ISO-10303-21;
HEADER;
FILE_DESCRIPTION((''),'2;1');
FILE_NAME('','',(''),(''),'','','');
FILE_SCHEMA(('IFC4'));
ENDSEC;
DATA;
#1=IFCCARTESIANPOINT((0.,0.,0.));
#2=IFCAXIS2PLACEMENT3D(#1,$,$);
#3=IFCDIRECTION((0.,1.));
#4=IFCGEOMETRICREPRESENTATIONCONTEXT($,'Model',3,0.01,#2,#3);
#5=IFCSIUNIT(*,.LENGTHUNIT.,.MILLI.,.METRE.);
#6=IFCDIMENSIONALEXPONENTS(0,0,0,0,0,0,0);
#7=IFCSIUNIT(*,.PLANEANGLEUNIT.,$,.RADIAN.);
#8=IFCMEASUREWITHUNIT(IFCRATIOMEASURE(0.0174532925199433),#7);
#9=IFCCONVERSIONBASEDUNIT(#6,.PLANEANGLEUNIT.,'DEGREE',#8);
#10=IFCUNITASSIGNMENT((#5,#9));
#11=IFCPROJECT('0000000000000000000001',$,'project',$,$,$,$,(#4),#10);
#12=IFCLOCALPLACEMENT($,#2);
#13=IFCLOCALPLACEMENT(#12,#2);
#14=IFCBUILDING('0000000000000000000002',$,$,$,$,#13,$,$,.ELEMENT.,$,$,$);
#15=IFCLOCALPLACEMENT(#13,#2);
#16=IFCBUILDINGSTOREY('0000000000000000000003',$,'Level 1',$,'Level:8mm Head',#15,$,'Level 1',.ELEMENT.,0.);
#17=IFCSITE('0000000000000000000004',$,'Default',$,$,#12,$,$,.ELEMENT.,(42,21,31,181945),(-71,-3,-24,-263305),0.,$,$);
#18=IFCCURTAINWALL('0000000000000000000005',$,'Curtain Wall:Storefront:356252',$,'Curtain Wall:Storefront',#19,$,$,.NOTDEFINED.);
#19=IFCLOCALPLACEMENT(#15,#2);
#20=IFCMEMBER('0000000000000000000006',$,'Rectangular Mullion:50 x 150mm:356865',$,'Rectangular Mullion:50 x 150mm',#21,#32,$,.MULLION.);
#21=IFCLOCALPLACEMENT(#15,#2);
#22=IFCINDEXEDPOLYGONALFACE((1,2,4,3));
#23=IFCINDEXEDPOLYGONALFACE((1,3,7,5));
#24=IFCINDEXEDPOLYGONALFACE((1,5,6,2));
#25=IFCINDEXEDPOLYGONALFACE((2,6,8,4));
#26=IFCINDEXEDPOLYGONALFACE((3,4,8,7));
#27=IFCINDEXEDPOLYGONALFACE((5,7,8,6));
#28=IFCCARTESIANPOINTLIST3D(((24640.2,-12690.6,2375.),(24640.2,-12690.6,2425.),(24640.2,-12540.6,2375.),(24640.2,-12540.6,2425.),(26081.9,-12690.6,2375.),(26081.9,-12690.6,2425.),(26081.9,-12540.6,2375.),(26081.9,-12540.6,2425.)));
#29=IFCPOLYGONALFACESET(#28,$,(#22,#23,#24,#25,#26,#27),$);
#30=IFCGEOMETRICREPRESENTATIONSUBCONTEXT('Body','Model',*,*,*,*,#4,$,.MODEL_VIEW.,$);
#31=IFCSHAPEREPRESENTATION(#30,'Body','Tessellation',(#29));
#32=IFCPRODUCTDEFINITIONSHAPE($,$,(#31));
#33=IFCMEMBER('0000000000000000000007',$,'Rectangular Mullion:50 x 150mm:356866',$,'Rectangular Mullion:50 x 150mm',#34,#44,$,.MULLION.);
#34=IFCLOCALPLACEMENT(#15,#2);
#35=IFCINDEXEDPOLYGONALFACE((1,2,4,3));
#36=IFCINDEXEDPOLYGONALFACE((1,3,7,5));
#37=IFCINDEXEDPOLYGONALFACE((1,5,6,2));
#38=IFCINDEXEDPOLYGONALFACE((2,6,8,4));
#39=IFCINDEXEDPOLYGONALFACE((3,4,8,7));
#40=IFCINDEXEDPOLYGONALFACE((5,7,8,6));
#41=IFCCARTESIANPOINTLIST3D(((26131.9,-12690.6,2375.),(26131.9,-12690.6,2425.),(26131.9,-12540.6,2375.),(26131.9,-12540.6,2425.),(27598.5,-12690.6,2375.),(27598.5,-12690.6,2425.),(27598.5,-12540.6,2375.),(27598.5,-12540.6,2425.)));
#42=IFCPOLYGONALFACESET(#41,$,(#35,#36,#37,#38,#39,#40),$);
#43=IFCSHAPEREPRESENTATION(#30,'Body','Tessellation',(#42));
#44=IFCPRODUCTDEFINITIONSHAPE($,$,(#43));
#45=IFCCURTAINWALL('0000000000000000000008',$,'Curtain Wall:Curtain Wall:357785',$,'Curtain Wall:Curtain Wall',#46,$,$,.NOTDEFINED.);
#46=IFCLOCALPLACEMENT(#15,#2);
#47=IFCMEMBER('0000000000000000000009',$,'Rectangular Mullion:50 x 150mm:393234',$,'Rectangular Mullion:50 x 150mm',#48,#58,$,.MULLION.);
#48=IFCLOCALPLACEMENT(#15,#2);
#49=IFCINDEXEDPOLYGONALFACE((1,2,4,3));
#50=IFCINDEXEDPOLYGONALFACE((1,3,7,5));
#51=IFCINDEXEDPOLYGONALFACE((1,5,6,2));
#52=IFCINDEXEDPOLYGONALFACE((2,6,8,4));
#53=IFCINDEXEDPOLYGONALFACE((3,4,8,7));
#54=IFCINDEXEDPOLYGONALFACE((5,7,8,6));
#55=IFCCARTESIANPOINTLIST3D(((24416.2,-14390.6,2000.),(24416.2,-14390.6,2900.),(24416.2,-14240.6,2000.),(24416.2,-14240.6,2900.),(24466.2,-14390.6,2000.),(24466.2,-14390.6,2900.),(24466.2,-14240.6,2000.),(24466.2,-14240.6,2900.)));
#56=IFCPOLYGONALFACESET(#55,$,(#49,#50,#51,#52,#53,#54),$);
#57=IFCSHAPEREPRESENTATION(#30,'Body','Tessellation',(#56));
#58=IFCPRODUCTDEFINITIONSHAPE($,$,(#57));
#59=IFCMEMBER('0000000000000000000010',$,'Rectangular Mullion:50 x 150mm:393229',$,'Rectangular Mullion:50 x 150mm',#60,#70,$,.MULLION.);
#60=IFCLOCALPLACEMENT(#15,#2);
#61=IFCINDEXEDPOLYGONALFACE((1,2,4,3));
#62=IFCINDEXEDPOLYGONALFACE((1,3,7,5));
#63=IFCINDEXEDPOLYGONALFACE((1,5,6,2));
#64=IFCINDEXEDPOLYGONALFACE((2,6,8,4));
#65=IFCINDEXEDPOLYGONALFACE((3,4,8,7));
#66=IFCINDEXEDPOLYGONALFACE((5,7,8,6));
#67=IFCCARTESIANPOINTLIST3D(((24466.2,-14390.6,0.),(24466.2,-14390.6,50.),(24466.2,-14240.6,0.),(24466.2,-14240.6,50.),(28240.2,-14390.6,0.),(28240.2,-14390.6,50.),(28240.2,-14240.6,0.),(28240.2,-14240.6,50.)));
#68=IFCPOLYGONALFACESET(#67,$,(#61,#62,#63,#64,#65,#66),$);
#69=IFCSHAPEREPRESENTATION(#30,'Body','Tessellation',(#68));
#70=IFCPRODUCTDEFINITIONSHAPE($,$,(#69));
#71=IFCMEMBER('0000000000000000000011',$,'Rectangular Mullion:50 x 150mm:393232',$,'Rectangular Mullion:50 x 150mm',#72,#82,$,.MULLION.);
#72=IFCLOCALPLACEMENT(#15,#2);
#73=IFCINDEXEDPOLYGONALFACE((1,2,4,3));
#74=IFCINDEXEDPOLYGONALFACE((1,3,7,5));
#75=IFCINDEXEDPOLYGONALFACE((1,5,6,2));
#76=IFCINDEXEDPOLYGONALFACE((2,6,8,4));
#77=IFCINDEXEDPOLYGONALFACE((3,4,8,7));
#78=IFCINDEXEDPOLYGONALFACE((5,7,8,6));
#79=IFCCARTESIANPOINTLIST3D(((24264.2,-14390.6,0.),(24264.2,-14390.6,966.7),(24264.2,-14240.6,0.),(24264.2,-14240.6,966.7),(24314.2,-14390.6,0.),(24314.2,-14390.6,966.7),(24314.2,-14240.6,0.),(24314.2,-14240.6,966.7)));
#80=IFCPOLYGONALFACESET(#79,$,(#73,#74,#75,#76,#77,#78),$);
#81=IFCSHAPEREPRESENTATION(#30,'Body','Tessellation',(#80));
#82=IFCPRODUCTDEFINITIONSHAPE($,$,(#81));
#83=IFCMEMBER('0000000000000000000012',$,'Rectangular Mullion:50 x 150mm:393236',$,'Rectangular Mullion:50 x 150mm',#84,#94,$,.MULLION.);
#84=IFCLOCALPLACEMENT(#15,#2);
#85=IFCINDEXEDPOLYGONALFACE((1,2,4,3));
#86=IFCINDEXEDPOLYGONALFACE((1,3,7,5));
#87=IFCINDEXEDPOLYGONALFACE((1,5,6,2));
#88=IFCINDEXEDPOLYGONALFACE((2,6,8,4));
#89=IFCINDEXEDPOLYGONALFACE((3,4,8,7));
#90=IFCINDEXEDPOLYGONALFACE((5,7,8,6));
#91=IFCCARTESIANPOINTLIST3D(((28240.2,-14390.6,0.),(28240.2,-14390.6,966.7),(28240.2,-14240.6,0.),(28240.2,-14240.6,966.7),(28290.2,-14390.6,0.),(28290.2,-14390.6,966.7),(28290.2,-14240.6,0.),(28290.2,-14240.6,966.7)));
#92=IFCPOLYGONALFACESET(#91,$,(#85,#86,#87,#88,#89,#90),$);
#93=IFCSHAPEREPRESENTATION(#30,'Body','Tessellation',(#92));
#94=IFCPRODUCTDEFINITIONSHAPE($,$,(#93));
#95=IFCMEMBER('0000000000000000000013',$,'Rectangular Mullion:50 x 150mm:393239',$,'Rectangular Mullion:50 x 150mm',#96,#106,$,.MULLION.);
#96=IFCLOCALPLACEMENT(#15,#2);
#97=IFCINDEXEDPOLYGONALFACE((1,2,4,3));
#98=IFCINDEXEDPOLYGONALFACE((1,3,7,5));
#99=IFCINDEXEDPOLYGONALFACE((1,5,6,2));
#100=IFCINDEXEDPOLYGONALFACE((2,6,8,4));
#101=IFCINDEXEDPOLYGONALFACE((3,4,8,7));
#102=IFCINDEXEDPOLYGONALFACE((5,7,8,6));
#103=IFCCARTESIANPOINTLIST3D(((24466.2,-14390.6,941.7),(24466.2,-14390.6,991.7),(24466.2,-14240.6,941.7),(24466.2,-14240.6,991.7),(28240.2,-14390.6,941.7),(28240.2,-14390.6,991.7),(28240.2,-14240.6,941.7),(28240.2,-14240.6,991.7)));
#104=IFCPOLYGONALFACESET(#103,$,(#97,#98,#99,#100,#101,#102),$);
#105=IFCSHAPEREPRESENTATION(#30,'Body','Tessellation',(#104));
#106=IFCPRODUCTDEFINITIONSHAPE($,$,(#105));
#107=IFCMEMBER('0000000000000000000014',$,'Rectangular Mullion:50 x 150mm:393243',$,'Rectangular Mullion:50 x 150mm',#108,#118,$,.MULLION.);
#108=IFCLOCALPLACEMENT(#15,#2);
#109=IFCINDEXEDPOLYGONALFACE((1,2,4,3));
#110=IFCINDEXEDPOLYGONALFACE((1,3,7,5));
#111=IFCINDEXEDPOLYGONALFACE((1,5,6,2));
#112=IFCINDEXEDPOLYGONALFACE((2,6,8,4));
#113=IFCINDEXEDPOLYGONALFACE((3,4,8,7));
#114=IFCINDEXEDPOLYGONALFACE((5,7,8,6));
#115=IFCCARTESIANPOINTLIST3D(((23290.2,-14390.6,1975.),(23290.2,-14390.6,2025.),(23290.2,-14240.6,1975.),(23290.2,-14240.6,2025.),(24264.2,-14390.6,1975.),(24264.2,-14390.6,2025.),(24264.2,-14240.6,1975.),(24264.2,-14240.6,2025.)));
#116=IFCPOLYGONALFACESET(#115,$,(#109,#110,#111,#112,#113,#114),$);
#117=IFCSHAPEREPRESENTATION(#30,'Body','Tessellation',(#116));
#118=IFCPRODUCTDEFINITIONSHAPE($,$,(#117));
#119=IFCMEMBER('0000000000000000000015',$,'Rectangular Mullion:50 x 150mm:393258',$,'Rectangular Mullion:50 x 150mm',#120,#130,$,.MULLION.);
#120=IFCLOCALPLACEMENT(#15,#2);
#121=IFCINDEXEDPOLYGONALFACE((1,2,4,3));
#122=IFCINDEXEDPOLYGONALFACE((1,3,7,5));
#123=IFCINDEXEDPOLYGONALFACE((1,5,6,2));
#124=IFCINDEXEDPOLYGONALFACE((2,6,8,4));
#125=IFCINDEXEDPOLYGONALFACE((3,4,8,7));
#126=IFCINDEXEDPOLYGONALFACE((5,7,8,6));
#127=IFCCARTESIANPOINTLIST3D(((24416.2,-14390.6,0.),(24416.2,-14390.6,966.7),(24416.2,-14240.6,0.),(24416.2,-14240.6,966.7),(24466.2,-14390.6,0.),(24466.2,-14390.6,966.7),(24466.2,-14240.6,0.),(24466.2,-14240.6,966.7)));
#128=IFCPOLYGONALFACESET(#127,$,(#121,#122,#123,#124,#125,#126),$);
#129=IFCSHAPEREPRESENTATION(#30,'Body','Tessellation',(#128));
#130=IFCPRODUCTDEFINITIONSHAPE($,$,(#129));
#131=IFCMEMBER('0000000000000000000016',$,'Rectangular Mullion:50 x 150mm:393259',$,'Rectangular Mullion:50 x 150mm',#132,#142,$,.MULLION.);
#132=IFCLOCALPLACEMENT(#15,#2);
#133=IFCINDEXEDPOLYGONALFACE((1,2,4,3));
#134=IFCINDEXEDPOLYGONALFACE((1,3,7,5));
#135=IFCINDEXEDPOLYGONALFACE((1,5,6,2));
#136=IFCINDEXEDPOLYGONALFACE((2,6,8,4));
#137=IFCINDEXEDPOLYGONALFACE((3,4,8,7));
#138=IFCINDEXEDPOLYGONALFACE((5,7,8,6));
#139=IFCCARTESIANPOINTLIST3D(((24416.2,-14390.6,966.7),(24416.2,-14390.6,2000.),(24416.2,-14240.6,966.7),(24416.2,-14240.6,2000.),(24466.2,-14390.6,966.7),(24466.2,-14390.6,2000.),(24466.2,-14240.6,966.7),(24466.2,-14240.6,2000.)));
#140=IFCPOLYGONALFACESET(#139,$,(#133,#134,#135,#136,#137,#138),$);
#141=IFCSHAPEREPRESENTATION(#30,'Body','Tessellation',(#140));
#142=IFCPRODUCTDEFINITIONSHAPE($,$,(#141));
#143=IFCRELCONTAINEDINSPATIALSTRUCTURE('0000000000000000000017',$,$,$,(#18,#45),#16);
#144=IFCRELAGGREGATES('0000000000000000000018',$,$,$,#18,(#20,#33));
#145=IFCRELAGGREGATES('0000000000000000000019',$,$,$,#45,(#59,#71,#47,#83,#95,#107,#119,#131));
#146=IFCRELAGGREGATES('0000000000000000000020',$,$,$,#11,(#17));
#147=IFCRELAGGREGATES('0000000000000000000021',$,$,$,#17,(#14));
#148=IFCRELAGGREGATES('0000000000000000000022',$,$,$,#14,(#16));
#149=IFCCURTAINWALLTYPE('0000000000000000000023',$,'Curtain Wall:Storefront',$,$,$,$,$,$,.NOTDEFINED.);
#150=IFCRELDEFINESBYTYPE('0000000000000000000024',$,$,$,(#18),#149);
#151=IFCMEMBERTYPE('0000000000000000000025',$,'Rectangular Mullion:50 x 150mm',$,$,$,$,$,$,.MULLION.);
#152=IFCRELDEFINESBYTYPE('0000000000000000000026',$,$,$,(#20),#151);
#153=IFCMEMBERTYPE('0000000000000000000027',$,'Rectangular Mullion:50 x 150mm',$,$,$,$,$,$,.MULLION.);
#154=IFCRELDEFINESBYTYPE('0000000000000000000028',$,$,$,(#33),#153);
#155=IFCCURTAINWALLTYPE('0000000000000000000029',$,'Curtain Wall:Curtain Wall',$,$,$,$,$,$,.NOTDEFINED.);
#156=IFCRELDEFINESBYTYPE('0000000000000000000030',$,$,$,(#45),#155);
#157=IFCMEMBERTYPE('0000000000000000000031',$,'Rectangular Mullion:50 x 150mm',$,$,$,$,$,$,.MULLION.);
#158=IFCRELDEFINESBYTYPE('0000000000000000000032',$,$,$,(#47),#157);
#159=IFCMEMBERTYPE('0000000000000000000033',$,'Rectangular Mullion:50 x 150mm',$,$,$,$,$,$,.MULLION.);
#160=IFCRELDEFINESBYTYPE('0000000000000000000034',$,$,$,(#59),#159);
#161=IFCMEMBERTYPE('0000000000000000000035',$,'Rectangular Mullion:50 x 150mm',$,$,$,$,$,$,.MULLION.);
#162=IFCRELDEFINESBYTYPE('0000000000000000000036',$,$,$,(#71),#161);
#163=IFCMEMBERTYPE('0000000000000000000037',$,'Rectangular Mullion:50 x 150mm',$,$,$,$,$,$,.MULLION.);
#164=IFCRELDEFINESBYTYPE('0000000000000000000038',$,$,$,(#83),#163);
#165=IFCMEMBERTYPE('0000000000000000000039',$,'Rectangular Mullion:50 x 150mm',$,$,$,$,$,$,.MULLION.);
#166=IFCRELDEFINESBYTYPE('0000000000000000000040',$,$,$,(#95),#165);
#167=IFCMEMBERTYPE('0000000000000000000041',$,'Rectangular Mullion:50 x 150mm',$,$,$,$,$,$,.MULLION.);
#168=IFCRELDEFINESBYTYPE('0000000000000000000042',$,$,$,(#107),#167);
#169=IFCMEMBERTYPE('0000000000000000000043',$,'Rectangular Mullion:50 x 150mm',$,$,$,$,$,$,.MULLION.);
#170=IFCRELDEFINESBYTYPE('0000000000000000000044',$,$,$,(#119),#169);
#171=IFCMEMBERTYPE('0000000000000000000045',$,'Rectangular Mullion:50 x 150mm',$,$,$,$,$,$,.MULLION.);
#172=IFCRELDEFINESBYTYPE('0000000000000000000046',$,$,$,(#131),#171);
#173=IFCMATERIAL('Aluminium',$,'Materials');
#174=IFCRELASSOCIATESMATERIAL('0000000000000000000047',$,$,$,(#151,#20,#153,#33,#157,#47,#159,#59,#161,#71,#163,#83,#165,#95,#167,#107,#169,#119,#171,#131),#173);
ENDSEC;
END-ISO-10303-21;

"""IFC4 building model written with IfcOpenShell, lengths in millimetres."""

from ifc_helpers import new_model, entity, si_unit, converted_unit, direction, frame, origin, place, context, subcontext, project, spatial, indexed_curve, outline, extrude, source, transform, mapped, material, type_object, type_shapes, element, aggregate, save


model = new_model("IFC4")

# Units and contexts
model_context = context("Model", 3, precision=0.01, world=origin(), true_north=direction((0.0, 1.0)))
body_context = subcontext(model_context, "Body", "Model", "MODEL_VIEW")
ifc_project = project(units=[si_unit("LENGTHUNIT", "METRE", prefix="MILLI"), converted_unit("PLANEANGLEUNIT", "DEGREE", entity("IfcRatioMeasure", 0.0174532925199433), si_unit("PLANEANGLEUNIT", "RADIAN"), dimensions=[0, 0, 0, 0, 0, 0, 0])], contexts=[model_context])

# Site, building, storey
site_placement = place(None, origin())
site = spatial("IfcSite", under=ifc_project, at=site_placement, Name="Default", CompositionType="ELEMENT", RefLatitude=(42, 21, 31, 181945), RefLongitude=(-71, -3, -24, -263305), RefElevation=0.0)
building_placement = place(site_placement, origin())
building = spatial("IfcBuilding", under=site, at=building_placement, CompositionType="ELEMENT")
storey_placement = place(building_placement, origin())
storey = spatial("IfcBuildingStorey", under=building, at=storey_placement, Name="Level 1", ObjectType="Level:8mm Head", LongName="Level 1", CompositionType="ELEMENT", Elevation=0.0)

# Curtain walls, members
curtain_wall_type_1 = type_object("IfcCurtainWallType", Name="Curtain Wall:Storefront", PredefinedType="NOTDEFINED")
curtain_wall_1_placement = place(storey_placement, origin())
curtain_wall_1 = element("IfcCurtainWall", 1, at=curtain_wall_1_placement, inside=storey, type_object=curtain_wall_type_1, Name="Curtain Wall:Storefront:356252", ObjectType="Curtain Wall:Storefront", PredefinedType="NOTDEFINED")
ifc_material_1 = material(Name="Aluminium", Category="Materials")
member_type_1 = type_object("IfcMemberType", Name="Rectangular Mullion:50 x 150mm", PredefinedType="MULLION", material=ifc_material_1)
shared_shape_1 = source(origin(), body_context, "Body", "SweptSolid", [
    extrude(outline(indexed_curve([(-75.0, -25.0), (75.0, -25.0), (75.0, 25.0), (-75.0, 25.0), (-75.0, -25.0)], self_intersect=False)), frame((0.0, 0.0, -1441.7), z_axis=(0.0, 0.0, 1.0), x_axis=(0.0, -1.0, 0.0)), (0.0, 0.0, 1.0), 1441.7),
])
type_shapes(member_type_1, [shared_shape_1])
member_1_placement = place(storey_placement, frame((26081.9, -12615.6, 2400.0), z_axis=(1.0, 0.0, 0.0), x_axis=(0.0, 0.0, 1.0)))
member_1 = element("IfcMember", 2, at=member_1_placement, type_object=member_type_1, material=ifc_material_1, Name="Rectangular Mullion:50 x 150mm:356865", ObjectType="Rectangular Mullion:50 x 150mm", PredefinedType="MULLION", context=body_context, shape_type="MappedRepresentation", body=[
    mapped(shared_shape_1, transform((0.0, 0.0, 0.0), scale=1.0)),
])
member_type_2 = type_object("IfcMemberType", Name="Rectangular Mullion:50 x 150mm", PredefinedType="MULLION", material=ifc_material_1)
shared_shape_2 = source(origin(), body_context, "Body", "SweptSolid", [
    extrude(outline(indexed_curve([(-75.0, -25.0), (75.0, -25.0), (75.0, 25.0), (-75.0, 25.0), (-75.0, -25.0)], self_intersect=False)), frame((0.0, 0.0, -1466.7), z_axis=(0.0, 0.0, 1.0), x_axis=(0.0, -1.0, 0.0)), (0.0, 0.0, 1.0), 1466.7),
])
type_shapes(member_type_2, [shared_shape_2])
member_2_placement = place(storey_placement, frame((27598.5, -12615.6, 2400.0), z_axis=(1.0, 0.0, 0.0), x_axis=(0.0, 0.0, 1.0)))
member_2 = element("IfcMember", 3, at=member_2_placement, type_object=member_type_2, material=ifc_material_1, Name="Rectangular Mullion:50 x 150mm:356866", ObjectType="Rectangular Mullion:50 x 150mm", PredefinedType="MULLION", context=body_context, shape_type="MappedRepresentation", body=[
    mapped(shared_shape_2, transform((0.0, 0.0, 0.0), scale=1.0)),
])
curtain_wall_type_2 = type_object("IfcCurtainWallType", Name="Curtain Wall:Curtain Wall", PredefinedType="NOTDEFINED")
curtain_wall_2_placement = place(storey_placement, origin())
curtain_wall_2 = element("IfcCurtainWall", 4, at=curtain_wall_2_placement, inside=storey, type_object=curtain_wall_type_2, Name="Curtain Wall:Curtain Wall:357785", ObjectType="Curtain Wall:Curtain Wall", PredefinedType="NOTDEFINED")
member_type_3 = type_object("IfcMemberType", Name="Rectangular Mullion:50 x 150mm", PredefinedType="MULLION", material=ifc_material_1)
shared_shape_3 = source(origin(), body_context, "Body", "SweptSolid", [
    extrude(outline(indexed_curve([(-75.0, -25.0), (75.0, -25.0), (75.0, 25.0), (-75.0, 25.0), (-75.0, -25.0)], self_intersect=False)), frame((-25.0, 0.0, -900.0), z_axis=(0.0, 0.0, 1.0), x_axis=(0.0, -1.0, 0.0)), (0.0, 0.0, 1.0), 900.0),
])
type_shapes(member_type_3, [shared_shape_3])
member_3_placement = place(storey_placement, frame((24416.2, -14315.6, 2900.0), z_axis=(0.0, 0.0, 1.0), x_axis=(-1.0, 0.0, 0.0)))
member_3 = element("IfcMember", 5, at=member_3_placement, type_object=member_type_3, material=ifc_material_1, Name="Rectangular Mullion:50 x 150mm:393234", ObjectType="Rectangular Mullion:50 x 150mm", PredefinedType="MULLION", context=body_context, shape_type="MappedRepresentation", body=[
    mapped(shared_shape_3, transform((0.0, 0.0, 0.0), scale=1.0)),
])
member_type_4 = type_object("IfcMemberType", Name="Rectangular Mullion:50 x 150mm", PredefinedType="MULLION", material=ifc_material_1)
shared_shape_4 = source(origin(), body_context, "Body", "SweptSolid", [
    extrude(outline(indexed_curve([(-75.0, -25.0), (75.0, -25.0), (75.0, 25.0), (-75.0, 25.0), (-75.0, -25.0)], self_intersect=False)), frame((-25.0, 0.0, -3774.0), z_axis=(0.0, 0.0, 1.0), x_axis=(0.0, -1.0, 0.0)), (0.0, 0.0, 1.0), 3774.0),
])
type_shapes(member_type_4, [shared_shape_4])
member_4_placement = place(storey_placement, frame((24466.2, -14315.6, 0.0), z_axis=(-1.0, 0.0, 0.0), x_axis=(0.0, 0.0, -1.0)))
member_4 = element("IfcMember", 6, at=member_4_placement, type_object=member_type_4, material=ifc_material_1, Name="Rectangular Mullion:50 x 150mm:393229", ObjectType="Rectangular Mullion:50 x 150mm", PredefinedType="MULLION", context=body_context, shape_type="MappedRepresentation", body=[
    mapped(shared_shape_4, transform((0.0, 0.0, 0.0), scale=1.0)),
])
member_type_5 = type_object("IfcMemberType", Name="Rectangular Mullion:50 x 150mm", PredefinedType="MULLION", material=ifc_material_1)
shared_shape_5 = source(origin(), body_context, "Body", "SweptSolid", [
    extrude(outline(indexed_curve([(-75.0, -25.0), (75.0, -25.0), (75.0, 25.0), (-75.0, 25.0), (-75.0, -25.0)], self_intersect=False)), frame((-25.0, 0.0, -966.7), z_axis=(0.0, 0.0, 1.0), x_axis=(0.0, -1.0, 0.0)), (0.0, 0.0, 1.0), 966.7),
])
type_shapes(member_type_5, [shared_shape_5])
member_5_placement = place(storey_placement, frame((24314.2, -14315.6, 0.0), z_axis=(0.0, 0.0, -1.0), x_axis=(1.0, 0.0, 0.0)))
member_5 = element("IfcMember", 7, at=member_5_placement, type_object=member_type_5, material=ifc_material_1, Name="Rectangular Mullion:50 x 150mm:393232", ObjectType="Rectangular Mullion:50 x 150mm", PredefinedType="MULLION", context=body_context, shape_type="MappedRepresentation", body=[
    mapped(shared_shape_5, transform((0.0, 0.0, 0.0), scale=1.0)),
])
member_type_6 = type_object("IfcMemberType", Name="Rectangular Mullion:50 x 150mm", PredefinedType="MULLION", material=ifc_material_1)
shared_shape_6 = source(origin(), body_context, "Body", "SweptSolid", [
    extrude(outline(indexed_curve([(-75.0, -25.0), (75.0, -25.0), (75.0, 25.0), (-75.0, 25.0), (-75.0, -25.0)], self_intersect=False)), frame((0.0, 0.0, -966.7), z_axis=(0.0, 0.0, 1.0), x_axis=(0.0, -1.0, 0.0)), (0.0, 0.0, 1.0), 966.7),
])
type_shapes(member_type_6, [shared_shape_6])
member_6_placement = place(storey_placement, frame((28265.2, -14315.6, 0.0), z_axis=(0.0, 0.0, -1.0), x_axis=(1.0, 0.0, 0.0)))
member_6 = element("IfcMember", 8, at=member_6_placement, type_object=member_type_6, material=ifc_material_1, Name="Rectangular Mullion:50 x 150mm:393236", ObjectType="Rectangular Mullion:50 x 150mm", PredefinedType="MULLION", context=body_context, shape_type="MappedRepresentation", body=[
    mapped(shared_shape_6, transform((0.0, 0.0, 0.0), scale=1.0)),
])
member_type_7 = type_object("IfcMemberType", Name="Rectangular Mullion:50 x 150mm", PredefinedType="MULLION", material=ifc_material_1)
shared_shape_7 = source(origin(), body_context, "Body", "SweptSolid", [
    extrude(outline(indexed_curve([(-75.0, -25.0), (75.0, -25.0), (75.0, 25.0), (-75.0, 25.0), (-75.0, -25.0)], self_intersect=False)), frame((0.0, 0.0, -3774.0), z_axis=(0.0, 0.0, 1.0), x_axis=(0.0, -1.0, 0.0)), (0.0, 0.0, 1.0), 3774.0),
])
type_shapes(member_type_7, [shared_shape_7])
member_7_placement = place(storey_placement, frame((28240.2, -14315.6, 966.7), z_axis=(1.0, 0.0, 0.0), x_axis=(0.0, 0.0, 1.0)))
member_7 = element("IfcMember", 9, at=member_7_placement, type_object=member_type_7, material=ifc_material_1, Name="Rectangular Mullion:50 x 150mm:393239", ObjectType="Rectangular Mullion:50 x 150mm", PredefinedType="MULLION", context=body_context, shape_type="MappedRepresentation", body=[
    mapped(shared_shape_7, transform((0.0, 0.0, 0.0), scale=1.0)),
])
member_type_8 = type_object("IfcMemberType", Name="Rectangular Mullion:50 x 150mm", PredefinedType="MULLION", material=ifc_material_1)
shared_shape_8 = source(origin(), body_context, "Body", "SweptSolid", [
    extrude(outline(indexed_curve([(-75.0, -25.0), (75.0, -25.0), (75.0, 25.0), (-75.0, 25.0), (-75.0, -25.0)], self_intersect=False)), frame((0.0, 0.0, -974.0), z_axis=(0.0, 0.0, 1.0), x_axis=(0.0, -1.0, 0.0)), (0.0, 0.0, 1.0), 974.0),
])
type_shapes(member_type_8, [shared_shape_8])
member_8_placement = place(storey_placement, frame((24264.2, -14315.6, 2000.0), z_axis=(1.0, 0.0, 0.0), x_axis=(0.0, 0.0, 1.0)))
member_8 = element("IfcMember", 10, at=member_8_placement, type_object=member_type_8, material=ifc_material_1, Name="Rectangular Mullion:50 x 150mm:393243", ObjectType="Rectangular Mullion:50 x 150mm", PredefinedType="MULLION", context=body_context, shape_type="MappedRepresentation", body=[
    mapped(shared_shape_8, transform((0.0, 0.0, 0.0), scale=1.0)),
])
member_type_9 = type_object("IfcMemberType", Name="Rectangular Mullion:50 x 150mm", PredefinedType="MULLION", material=ifc_material_1)
shared_shape_9 = source(origin(), body_context, "Body", "SweptSolid", [
    extrude(outline(indexed_curve([(-75.0, -25.0), (75.0, -25.0), (75.0, 25.0), (-75.0, 25.0), (-75.0, -25.0)], self_intersect=False)), frame((-25.0, 0.0, -966.7), z_axis=(0.0, 0.0, 1.0), x_axis=(0.0, -1.0, 0.0)), (0.0, 0.0, 1.0), 966.7),
])
type_shapes(member_type_9, [shared_shape_9])
member_9_placement = place(storey_placement, frame((24416.2, -14315.6, 966.7), z_axis=(0.0, 0.0, 1.0), x_axis=(-1.0, 0.0, 0.0)))
member_9 = element("IfcMember", 11, at=member_9_placement, type_object=member_type_9, material=ifc_material_1, Name="Rectangular Mullion:50 x 150mm:393258", ObjectType="Rectangular Mullion:50 x 150mm", PredefinedType="MULLION", context=body_context, shape_type="MappedRepresentation", body=[
    mapped(shared_shape_9, transform((0.0, 0.0, 0.0), scale=1.0)),
])
member_type_10 = type_object("IfcMemberType", Name="Rectangular Mullion:50 x 150mm", PredefinedType="MULLION", material=ifc_material_1)
shared_shape_10 = source(origin(), body_context, "Body", "SweptSolid", [
    extrude(outline(indexed_curve([(-75.0, -25.0), (75.0, -25.0), (75.0, 25.0), (-75.0, 25.0), (-75.0, -25.0)], self_intersect=False)), frame((-25.0, 0.0, -1033.3), z_axis=(0.0, 0.0, 1.0), x_axis=(0.0, -1.0, 0.0)), (0.0, 0.0, 1.0), 1033.3),
])
type_shapes(member_type_10, [shared_shape_10])
member_10_placement = place(storey_placement, frame((24416.2, -14315.6, 2000.0), z_axis=(0.0, 0.0, 1.0), x_axis=(-1.0, 0.0, 0.0)))
member_10 = element("IfcMember", 12, at=member_10_placement, type_object=member_type_10, material=ifc_material_1, Name="Rectangular Mullion:50 x 150mm:393259", ObjectType="Rectangular Mullion:50 x 150mm", PredefinedType="MULLION", context=body_context, shape_type="MappedRepresentation", body=[
    mapped(shared_shape_10, transform((0.0, 0.0, 0.0), scale=1.0)),
])

aggregate(curtain_wall_1, [member_1, member_2])

aggregate(curtain_wall_2, [member_4, member_5, member_3, member_6, member_7, member_8, member_9, member_10])

save(model, "model.ifc")
